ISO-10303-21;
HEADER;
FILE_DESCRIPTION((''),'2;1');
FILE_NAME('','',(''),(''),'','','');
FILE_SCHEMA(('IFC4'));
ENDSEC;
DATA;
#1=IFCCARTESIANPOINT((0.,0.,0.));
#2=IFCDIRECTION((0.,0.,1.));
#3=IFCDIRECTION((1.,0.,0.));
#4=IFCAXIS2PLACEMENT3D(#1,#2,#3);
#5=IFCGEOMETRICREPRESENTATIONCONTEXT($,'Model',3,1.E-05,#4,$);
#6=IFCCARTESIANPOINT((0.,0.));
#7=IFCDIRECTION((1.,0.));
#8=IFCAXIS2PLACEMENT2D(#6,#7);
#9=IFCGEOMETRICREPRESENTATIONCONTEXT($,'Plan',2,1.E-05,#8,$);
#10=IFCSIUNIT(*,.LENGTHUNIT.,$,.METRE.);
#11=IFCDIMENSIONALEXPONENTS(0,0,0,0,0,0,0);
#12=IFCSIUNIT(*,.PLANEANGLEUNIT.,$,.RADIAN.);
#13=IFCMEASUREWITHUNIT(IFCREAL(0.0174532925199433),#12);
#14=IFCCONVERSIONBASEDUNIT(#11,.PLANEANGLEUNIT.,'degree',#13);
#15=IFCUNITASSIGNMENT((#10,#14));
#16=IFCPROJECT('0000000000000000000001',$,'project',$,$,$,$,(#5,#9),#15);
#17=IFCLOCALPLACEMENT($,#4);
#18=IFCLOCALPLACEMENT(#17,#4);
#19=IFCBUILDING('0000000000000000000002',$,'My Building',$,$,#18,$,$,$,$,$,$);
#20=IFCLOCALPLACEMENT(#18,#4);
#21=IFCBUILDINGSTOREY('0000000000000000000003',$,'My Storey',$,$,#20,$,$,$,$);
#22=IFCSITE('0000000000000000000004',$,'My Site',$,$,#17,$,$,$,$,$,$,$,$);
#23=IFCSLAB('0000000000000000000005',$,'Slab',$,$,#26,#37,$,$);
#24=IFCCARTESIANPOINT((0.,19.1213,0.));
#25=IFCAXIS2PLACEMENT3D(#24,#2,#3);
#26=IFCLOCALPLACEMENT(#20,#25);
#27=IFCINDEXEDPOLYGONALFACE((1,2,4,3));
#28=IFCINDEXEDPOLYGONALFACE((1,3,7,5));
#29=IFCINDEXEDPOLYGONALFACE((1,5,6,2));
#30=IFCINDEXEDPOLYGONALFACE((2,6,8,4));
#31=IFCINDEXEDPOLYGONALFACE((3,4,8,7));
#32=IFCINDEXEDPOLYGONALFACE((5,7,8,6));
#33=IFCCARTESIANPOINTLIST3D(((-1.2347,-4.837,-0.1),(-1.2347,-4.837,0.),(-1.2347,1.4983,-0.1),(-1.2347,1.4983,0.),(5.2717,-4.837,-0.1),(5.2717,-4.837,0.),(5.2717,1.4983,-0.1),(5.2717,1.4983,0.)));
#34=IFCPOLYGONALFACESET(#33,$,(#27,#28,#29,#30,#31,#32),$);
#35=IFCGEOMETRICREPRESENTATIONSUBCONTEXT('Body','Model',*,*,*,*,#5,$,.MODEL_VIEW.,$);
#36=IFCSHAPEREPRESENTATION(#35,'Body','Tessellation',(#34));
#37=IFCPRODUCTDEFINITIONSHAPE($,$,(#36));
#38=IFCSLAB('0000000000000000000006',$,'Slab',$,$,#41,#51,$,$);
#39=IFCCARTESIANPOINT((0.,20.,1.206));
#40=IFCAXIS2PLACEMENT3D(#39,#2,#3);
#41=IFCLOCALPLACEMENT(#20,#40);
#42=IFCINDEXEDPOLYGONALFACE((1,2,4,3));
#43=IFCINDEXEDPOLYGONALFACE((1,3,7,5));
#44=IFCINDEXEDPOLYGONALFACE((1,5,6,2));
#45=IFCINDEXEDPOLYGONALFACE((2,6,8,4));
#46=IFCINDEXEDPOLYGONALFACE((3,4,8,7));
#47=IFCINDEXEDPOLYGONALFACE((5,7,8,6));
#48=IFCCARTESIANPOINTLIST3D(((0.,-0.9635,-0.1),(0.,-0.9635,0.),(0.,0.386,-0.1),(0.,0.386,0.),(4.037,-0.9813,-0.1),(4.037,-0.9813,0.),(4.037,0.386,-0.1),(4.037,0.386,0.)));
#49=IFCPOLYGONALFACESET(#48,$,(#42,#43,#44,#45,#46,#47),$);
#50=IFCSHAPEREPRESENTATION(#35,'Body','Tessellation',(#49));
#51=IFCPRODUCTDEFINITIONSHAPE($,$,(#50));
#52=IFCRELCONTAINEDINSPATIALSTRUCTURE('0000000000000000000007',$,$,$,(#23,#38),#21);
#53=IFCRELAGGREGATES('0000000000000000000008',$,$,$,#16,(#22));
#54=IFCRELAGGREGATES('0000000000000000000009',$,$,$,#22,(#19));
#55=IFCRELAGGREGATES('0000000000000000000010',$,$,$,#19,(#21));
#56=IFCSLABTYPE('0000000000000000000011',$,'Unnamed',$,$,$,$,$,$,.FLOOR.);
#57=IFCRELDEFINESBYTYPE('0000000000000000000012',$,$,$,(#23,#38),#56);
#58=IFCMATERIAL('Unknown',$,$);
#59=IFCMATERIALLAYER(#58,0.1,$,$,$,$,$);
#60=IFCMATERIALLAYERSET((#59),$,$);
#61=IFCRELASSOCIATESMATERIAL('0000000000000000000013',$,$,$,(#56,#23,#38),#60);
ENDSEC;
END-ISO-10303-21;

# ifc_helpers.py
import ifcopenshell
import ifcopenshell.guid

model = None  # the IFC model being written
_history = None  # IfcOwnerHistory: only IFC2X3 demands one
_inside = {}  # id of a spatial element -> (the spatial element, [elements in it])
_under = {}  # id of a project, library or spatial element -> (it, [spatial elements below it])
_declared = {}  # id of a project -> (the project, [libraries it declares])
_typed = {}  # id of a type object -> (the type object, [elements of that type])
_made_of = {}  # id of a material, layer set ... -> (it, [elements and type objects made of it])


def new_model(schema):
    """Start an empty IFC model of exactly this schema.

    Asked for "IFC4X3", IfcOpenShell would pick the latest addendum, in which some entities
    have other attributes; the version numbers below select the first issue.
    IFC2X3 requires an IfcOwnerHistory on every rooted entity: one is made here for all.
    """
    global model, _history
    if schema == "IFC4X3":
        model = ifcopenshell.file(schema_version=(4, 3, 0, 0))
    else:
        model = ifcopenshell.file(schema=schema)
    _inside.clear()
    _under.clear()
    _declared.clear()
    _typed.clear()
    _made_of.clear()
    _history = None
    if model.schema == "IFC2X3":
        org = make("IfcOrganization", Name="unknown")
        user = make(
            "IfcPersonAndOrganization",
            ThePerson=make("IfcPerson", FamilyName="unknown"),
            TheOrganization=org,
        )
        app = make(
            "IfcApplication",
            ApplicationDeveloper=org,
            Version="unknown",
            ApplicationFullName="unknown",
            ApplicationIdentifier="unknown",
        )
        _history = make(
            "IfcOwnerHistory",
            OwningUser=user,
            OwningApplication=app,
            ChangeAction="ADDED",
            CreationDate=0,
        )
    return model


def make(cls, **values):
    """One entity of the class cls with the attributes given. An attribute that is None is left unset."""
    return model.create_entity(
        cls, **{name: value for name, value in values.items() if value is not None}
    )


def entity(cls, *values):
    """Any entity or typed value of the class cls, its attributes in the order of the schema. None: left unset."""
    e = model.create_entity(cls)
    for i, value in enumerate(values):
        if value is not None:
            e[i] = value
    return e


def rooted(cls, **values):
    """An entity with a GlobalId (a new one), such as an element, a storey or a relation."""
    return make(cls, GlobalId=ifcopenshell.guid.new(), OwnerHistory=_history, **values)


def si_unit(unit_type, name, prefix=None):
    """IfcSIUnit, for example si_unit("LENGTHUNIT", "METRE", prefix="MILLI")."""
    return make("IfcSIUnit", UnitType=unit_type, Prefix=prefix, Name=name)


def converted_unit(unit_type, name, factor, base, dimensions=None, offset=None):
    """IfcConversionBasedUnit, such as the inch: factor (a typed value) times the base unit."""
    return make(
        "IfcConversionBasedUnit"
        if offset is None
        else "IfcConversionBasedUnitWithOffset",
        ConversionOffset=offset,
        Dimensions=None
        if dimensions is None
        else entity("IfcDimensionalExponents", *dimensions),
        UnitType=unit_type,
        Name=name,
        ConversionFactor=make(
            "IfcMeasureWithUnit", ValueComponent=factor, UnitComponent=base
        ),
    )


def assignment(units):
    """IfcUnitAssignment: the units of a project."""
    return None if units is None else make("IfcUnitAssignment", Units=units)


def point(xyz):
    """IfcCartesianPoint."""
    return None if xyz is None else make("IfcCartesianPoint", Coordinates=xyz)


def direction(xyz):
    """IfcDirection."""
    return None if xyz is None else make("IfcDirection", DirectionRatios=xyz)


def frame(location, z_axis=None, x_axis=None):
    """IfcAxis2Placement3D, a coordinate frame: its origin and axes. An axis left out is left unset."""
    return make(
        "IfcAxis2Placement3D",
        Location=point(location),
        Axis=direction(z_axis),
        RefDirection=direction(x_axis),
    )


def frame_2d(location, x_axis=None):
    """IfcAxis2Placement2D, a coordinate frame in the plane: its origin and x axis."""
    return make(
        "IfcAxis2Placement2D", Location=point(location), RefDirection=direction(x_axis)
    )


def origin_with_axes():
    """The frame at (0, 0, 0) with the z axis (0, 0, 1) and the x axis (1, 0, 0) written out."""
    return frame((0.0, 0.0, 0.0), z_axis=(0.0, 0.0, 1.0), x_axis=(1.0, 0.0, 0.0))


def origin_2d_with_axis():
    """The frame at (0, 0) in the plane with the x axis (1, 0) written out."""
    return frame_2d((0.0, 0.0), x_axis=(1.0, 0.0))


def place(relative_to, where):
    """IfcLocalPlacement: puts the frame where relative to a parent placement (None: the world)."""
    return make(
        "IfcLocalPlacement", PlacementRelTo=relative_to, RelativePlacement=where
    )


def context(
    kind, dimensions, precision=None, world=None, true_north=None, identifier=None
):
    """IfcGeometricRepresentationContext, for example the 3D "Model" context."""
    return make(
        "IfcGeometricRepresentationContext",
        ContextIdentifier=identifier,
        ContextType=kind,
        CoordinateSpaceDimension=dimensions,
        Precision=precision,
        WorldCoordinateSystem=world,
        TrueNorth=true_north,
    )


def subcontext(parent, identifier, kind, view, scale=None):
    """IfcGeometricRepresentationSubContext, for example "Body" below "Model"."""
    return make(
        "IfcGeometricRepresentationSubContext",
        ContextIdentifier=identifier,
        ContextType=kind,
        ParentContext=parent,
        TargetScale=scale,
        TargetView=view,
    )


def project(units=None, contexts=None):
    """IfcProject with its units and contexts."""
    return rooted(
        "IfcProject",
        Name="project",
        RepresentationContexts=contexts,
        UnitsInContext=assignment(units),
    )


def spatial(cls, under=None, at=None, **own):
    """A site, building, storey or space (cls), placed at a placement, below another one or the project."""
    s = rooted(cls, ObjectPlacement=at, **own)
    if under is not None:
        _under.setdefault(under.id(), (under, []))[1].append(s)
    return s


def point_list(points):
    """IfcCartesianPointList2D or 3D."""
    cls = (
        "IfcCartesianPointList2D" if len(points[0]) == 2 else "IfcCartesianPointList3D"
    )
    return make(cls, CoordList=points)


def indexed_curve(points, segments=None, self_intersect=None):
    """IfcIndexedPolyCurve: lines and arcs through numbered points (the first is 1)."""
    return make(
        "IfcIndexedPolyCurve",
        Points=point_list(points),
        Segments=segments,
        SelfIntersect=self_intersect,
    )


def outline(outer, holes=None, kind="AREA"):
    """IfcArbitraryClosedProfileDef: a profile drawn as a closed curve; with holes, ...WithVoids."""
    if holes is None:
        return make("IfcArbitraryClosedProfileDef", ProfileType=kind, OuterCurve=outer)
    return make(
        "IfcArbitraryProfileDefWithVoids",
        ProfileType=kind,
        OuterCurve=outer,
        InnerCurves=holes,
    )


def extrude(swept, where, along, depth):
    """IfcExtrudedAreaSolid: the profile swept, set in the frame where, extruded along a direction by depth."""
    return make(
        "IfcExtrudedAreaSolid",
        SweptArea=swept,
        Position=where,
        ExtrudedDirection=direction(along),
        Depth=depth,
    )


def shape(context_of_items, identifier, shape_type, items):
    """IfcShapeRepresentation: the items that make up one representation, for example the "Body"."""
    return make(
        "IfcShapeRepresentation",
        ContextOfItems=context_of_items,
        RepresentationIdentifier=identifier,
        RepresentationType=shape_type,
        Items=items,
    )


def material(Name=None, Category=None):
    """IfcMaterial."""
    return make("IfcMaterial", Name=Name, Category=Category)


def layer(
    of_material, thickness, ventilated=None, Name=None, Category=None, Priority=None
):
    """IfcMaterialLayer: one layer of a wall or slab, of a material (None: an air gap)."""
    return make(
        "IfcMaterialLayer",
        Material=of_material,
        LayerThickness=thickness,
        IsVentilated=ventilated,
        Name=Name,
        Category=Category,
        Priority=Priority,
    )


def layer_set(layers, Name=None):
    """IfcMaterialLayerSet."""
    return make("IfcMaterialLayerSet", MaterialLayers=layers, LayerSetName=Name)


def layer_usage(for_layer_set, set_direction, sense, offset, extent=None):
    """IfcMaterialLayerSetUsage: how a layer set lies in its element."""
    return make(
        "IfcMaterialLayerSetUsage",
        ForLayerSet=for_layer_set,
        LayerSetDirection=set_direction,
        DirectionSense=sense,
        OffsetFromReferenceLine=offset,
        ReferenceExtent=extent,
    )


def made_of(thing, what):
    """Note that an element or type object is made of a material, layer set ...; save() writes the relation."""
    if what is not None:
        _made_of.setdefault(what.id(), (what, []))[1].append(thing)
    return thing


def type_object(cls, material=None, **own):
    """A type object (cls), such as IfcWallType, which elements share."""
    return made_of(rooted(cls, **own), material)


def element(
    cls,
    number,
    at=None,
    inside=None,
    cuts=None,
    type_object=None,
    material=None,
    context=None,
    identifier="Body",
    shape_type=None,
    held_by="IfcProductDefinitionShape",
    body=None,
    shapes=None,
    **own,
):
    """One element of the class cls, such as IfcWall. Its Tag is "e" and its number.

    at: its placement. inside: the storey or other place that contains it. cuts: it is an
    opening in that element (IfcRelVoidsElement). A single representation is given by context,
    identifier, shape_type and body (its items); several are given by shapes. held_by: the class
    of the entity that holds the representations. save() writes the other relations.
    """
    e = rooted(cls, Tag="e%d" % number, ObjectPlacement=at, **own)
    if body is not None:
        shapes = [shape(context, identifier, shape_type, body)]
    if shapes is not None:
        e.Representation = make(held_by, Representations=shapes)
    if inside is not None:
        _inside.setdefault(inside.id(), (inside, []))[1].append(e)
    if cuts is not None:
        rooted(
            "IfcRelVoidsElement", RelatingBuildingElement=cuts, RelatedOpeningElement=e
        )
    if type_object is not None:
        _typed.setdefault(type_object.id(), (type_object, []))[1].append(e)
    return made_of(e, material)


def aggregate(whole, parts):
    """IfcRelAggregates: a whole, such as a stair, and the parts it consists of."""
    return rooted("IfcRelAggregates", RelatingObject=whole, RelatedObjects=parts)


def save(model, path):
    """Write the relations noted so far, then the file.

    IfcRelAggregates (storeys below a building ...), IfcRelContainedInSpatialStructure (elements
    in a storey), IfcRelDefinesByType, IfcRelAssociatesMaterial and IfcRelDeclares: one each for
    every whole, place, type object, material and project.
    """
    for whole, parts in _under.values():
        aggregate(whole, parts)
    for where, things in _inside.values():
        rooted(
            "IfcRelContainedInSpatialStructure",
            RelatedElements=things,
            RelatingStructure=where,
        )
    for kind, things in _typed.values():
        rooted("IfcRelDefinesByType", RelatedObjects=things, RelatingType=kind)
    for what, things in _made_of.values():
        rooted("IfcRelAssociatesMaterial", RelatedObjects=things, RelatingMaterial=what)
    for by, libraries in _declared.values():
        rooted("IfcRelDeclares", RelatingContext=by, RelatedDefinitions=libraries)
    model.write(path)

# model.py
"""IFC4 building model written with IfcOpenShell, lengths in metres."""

from ifc_helpers import new_model, entity, si_unit, converted_unit, frame, origin_with_axes, origin_2d_with_axis, place, context, subcontext, project, spatial, indexed_curve, outline, extrude, material, layer, layer_set, layer_usage, type_object, element, save


model = new_model("IFC4")

# Units and contexts
model_context = context("Model", 3, precision=1e-05, world=origin_with_axes())
plan_context = context("Plan", 2, precision=1e-05, world=origin_2d_with_axis())
body_context = subcontext(model_context, "Body", "Model", "MODEL_VIEW")
ifc_project = project(units=[si_unit("LENGTHUNIT", "METRE"), converted_unit("PLANEANGLEUNIT", "degree", entity("IfcReal", 0.0174532925199433), si_unit("PLANEANGLEUNIT", "RADIAN"), dimensions=[0, 0, 0, 0, 0, 0, 0])], contexts=[model_context, plan_context])

# Site, building, storey
site_placement = place(None, origin_with_axes())
site = spatial("IfcSite", under=ifc_project, at=site_placement, Name="My Site")
building_placement = place(site_placement, origin_with_axes())
building = spatial("IfcBuilding", under=site, at=building_placement, Name="My Building")
storey_placement = place(building_placement, origin_with_axes())
storey = spatial("IfcBuildingStorey", under=building, at=storey_placement, Name="My Storey")

# Shared definitions
ifc_material = material(Name="Unknown")

# Slabs
ifc_layer_1 = layer(ifc_material, 0.1)
ifc_layer_set_1 = layer_set([ifc_layer_1])
ifc_layer_usage_1 = layer_usage(ifc_layer_set_1, "AXIS3", "POSITIVE", -0.1)
slab_type = type_object("IfcSlabType", Name="Unnamed", PredefinedType="FLOOR", material=ifc_layer_set_1)
slab_1_placement = place(storey_placement, frame((0.0, 19.1213, 0.0), z_axis=(0.0, 0.0, 1.0), x_axis=(1.0, 0.0, 0.0)))
element("IfcSlab", 1, at=slab_1_placement, inside=storey, type_object=slab_type, material=ifc_layer_usage_1, Name="Slab", context=body_context, shape_type="SweptSolid", body=[
    extrude(outline(indexed_curve([(5.2717, 1.4983), (5.2717, -4.837), (-1.2347, -4.837), (-1.2347, 1.4983), (5.2717, 1.4983)])), frame((0.0, 0.0, -0.1), z_axis=(0.0, 0.0, 1.0), x_axis=(1.0, 0.0, 0.0)), (0.0, 0.0, 1.0), 0.1),
])
ifc_layer_usage_2 = layer_usage(ifc_layer_set_1, "AXIS3", "POSITIVE", -0.1)
slab_2_placement = place(storey_placement, frame((0.0, 20.0, 1.206), z_axis=(0.0, 0.0, 1.0), x_axis=(1.0, 0.0, 0.0)))
element("IfcSlab", 2, at=slab_2_placement, inside=storey, type_object=slab_type, material=ifc_layer_usage_2, Name="Slab", context=body_context, shape_type="SweptSolid", body=[
    extrude(outline(indexed_curve([(4.037, 0.386), (4.037, -0.9813), (0.0, -0.9635), (0.0, 0.386), (4.037, 0.386)])), frame((0.0, 0.0, -0.1), z_axis=(0.0, 0.0, 1.0), x_axis=(1.0, 0.0, 0.0)), (0.0, 0.0, 1.0), 0.1),
])

save(model, "model.ifc")
